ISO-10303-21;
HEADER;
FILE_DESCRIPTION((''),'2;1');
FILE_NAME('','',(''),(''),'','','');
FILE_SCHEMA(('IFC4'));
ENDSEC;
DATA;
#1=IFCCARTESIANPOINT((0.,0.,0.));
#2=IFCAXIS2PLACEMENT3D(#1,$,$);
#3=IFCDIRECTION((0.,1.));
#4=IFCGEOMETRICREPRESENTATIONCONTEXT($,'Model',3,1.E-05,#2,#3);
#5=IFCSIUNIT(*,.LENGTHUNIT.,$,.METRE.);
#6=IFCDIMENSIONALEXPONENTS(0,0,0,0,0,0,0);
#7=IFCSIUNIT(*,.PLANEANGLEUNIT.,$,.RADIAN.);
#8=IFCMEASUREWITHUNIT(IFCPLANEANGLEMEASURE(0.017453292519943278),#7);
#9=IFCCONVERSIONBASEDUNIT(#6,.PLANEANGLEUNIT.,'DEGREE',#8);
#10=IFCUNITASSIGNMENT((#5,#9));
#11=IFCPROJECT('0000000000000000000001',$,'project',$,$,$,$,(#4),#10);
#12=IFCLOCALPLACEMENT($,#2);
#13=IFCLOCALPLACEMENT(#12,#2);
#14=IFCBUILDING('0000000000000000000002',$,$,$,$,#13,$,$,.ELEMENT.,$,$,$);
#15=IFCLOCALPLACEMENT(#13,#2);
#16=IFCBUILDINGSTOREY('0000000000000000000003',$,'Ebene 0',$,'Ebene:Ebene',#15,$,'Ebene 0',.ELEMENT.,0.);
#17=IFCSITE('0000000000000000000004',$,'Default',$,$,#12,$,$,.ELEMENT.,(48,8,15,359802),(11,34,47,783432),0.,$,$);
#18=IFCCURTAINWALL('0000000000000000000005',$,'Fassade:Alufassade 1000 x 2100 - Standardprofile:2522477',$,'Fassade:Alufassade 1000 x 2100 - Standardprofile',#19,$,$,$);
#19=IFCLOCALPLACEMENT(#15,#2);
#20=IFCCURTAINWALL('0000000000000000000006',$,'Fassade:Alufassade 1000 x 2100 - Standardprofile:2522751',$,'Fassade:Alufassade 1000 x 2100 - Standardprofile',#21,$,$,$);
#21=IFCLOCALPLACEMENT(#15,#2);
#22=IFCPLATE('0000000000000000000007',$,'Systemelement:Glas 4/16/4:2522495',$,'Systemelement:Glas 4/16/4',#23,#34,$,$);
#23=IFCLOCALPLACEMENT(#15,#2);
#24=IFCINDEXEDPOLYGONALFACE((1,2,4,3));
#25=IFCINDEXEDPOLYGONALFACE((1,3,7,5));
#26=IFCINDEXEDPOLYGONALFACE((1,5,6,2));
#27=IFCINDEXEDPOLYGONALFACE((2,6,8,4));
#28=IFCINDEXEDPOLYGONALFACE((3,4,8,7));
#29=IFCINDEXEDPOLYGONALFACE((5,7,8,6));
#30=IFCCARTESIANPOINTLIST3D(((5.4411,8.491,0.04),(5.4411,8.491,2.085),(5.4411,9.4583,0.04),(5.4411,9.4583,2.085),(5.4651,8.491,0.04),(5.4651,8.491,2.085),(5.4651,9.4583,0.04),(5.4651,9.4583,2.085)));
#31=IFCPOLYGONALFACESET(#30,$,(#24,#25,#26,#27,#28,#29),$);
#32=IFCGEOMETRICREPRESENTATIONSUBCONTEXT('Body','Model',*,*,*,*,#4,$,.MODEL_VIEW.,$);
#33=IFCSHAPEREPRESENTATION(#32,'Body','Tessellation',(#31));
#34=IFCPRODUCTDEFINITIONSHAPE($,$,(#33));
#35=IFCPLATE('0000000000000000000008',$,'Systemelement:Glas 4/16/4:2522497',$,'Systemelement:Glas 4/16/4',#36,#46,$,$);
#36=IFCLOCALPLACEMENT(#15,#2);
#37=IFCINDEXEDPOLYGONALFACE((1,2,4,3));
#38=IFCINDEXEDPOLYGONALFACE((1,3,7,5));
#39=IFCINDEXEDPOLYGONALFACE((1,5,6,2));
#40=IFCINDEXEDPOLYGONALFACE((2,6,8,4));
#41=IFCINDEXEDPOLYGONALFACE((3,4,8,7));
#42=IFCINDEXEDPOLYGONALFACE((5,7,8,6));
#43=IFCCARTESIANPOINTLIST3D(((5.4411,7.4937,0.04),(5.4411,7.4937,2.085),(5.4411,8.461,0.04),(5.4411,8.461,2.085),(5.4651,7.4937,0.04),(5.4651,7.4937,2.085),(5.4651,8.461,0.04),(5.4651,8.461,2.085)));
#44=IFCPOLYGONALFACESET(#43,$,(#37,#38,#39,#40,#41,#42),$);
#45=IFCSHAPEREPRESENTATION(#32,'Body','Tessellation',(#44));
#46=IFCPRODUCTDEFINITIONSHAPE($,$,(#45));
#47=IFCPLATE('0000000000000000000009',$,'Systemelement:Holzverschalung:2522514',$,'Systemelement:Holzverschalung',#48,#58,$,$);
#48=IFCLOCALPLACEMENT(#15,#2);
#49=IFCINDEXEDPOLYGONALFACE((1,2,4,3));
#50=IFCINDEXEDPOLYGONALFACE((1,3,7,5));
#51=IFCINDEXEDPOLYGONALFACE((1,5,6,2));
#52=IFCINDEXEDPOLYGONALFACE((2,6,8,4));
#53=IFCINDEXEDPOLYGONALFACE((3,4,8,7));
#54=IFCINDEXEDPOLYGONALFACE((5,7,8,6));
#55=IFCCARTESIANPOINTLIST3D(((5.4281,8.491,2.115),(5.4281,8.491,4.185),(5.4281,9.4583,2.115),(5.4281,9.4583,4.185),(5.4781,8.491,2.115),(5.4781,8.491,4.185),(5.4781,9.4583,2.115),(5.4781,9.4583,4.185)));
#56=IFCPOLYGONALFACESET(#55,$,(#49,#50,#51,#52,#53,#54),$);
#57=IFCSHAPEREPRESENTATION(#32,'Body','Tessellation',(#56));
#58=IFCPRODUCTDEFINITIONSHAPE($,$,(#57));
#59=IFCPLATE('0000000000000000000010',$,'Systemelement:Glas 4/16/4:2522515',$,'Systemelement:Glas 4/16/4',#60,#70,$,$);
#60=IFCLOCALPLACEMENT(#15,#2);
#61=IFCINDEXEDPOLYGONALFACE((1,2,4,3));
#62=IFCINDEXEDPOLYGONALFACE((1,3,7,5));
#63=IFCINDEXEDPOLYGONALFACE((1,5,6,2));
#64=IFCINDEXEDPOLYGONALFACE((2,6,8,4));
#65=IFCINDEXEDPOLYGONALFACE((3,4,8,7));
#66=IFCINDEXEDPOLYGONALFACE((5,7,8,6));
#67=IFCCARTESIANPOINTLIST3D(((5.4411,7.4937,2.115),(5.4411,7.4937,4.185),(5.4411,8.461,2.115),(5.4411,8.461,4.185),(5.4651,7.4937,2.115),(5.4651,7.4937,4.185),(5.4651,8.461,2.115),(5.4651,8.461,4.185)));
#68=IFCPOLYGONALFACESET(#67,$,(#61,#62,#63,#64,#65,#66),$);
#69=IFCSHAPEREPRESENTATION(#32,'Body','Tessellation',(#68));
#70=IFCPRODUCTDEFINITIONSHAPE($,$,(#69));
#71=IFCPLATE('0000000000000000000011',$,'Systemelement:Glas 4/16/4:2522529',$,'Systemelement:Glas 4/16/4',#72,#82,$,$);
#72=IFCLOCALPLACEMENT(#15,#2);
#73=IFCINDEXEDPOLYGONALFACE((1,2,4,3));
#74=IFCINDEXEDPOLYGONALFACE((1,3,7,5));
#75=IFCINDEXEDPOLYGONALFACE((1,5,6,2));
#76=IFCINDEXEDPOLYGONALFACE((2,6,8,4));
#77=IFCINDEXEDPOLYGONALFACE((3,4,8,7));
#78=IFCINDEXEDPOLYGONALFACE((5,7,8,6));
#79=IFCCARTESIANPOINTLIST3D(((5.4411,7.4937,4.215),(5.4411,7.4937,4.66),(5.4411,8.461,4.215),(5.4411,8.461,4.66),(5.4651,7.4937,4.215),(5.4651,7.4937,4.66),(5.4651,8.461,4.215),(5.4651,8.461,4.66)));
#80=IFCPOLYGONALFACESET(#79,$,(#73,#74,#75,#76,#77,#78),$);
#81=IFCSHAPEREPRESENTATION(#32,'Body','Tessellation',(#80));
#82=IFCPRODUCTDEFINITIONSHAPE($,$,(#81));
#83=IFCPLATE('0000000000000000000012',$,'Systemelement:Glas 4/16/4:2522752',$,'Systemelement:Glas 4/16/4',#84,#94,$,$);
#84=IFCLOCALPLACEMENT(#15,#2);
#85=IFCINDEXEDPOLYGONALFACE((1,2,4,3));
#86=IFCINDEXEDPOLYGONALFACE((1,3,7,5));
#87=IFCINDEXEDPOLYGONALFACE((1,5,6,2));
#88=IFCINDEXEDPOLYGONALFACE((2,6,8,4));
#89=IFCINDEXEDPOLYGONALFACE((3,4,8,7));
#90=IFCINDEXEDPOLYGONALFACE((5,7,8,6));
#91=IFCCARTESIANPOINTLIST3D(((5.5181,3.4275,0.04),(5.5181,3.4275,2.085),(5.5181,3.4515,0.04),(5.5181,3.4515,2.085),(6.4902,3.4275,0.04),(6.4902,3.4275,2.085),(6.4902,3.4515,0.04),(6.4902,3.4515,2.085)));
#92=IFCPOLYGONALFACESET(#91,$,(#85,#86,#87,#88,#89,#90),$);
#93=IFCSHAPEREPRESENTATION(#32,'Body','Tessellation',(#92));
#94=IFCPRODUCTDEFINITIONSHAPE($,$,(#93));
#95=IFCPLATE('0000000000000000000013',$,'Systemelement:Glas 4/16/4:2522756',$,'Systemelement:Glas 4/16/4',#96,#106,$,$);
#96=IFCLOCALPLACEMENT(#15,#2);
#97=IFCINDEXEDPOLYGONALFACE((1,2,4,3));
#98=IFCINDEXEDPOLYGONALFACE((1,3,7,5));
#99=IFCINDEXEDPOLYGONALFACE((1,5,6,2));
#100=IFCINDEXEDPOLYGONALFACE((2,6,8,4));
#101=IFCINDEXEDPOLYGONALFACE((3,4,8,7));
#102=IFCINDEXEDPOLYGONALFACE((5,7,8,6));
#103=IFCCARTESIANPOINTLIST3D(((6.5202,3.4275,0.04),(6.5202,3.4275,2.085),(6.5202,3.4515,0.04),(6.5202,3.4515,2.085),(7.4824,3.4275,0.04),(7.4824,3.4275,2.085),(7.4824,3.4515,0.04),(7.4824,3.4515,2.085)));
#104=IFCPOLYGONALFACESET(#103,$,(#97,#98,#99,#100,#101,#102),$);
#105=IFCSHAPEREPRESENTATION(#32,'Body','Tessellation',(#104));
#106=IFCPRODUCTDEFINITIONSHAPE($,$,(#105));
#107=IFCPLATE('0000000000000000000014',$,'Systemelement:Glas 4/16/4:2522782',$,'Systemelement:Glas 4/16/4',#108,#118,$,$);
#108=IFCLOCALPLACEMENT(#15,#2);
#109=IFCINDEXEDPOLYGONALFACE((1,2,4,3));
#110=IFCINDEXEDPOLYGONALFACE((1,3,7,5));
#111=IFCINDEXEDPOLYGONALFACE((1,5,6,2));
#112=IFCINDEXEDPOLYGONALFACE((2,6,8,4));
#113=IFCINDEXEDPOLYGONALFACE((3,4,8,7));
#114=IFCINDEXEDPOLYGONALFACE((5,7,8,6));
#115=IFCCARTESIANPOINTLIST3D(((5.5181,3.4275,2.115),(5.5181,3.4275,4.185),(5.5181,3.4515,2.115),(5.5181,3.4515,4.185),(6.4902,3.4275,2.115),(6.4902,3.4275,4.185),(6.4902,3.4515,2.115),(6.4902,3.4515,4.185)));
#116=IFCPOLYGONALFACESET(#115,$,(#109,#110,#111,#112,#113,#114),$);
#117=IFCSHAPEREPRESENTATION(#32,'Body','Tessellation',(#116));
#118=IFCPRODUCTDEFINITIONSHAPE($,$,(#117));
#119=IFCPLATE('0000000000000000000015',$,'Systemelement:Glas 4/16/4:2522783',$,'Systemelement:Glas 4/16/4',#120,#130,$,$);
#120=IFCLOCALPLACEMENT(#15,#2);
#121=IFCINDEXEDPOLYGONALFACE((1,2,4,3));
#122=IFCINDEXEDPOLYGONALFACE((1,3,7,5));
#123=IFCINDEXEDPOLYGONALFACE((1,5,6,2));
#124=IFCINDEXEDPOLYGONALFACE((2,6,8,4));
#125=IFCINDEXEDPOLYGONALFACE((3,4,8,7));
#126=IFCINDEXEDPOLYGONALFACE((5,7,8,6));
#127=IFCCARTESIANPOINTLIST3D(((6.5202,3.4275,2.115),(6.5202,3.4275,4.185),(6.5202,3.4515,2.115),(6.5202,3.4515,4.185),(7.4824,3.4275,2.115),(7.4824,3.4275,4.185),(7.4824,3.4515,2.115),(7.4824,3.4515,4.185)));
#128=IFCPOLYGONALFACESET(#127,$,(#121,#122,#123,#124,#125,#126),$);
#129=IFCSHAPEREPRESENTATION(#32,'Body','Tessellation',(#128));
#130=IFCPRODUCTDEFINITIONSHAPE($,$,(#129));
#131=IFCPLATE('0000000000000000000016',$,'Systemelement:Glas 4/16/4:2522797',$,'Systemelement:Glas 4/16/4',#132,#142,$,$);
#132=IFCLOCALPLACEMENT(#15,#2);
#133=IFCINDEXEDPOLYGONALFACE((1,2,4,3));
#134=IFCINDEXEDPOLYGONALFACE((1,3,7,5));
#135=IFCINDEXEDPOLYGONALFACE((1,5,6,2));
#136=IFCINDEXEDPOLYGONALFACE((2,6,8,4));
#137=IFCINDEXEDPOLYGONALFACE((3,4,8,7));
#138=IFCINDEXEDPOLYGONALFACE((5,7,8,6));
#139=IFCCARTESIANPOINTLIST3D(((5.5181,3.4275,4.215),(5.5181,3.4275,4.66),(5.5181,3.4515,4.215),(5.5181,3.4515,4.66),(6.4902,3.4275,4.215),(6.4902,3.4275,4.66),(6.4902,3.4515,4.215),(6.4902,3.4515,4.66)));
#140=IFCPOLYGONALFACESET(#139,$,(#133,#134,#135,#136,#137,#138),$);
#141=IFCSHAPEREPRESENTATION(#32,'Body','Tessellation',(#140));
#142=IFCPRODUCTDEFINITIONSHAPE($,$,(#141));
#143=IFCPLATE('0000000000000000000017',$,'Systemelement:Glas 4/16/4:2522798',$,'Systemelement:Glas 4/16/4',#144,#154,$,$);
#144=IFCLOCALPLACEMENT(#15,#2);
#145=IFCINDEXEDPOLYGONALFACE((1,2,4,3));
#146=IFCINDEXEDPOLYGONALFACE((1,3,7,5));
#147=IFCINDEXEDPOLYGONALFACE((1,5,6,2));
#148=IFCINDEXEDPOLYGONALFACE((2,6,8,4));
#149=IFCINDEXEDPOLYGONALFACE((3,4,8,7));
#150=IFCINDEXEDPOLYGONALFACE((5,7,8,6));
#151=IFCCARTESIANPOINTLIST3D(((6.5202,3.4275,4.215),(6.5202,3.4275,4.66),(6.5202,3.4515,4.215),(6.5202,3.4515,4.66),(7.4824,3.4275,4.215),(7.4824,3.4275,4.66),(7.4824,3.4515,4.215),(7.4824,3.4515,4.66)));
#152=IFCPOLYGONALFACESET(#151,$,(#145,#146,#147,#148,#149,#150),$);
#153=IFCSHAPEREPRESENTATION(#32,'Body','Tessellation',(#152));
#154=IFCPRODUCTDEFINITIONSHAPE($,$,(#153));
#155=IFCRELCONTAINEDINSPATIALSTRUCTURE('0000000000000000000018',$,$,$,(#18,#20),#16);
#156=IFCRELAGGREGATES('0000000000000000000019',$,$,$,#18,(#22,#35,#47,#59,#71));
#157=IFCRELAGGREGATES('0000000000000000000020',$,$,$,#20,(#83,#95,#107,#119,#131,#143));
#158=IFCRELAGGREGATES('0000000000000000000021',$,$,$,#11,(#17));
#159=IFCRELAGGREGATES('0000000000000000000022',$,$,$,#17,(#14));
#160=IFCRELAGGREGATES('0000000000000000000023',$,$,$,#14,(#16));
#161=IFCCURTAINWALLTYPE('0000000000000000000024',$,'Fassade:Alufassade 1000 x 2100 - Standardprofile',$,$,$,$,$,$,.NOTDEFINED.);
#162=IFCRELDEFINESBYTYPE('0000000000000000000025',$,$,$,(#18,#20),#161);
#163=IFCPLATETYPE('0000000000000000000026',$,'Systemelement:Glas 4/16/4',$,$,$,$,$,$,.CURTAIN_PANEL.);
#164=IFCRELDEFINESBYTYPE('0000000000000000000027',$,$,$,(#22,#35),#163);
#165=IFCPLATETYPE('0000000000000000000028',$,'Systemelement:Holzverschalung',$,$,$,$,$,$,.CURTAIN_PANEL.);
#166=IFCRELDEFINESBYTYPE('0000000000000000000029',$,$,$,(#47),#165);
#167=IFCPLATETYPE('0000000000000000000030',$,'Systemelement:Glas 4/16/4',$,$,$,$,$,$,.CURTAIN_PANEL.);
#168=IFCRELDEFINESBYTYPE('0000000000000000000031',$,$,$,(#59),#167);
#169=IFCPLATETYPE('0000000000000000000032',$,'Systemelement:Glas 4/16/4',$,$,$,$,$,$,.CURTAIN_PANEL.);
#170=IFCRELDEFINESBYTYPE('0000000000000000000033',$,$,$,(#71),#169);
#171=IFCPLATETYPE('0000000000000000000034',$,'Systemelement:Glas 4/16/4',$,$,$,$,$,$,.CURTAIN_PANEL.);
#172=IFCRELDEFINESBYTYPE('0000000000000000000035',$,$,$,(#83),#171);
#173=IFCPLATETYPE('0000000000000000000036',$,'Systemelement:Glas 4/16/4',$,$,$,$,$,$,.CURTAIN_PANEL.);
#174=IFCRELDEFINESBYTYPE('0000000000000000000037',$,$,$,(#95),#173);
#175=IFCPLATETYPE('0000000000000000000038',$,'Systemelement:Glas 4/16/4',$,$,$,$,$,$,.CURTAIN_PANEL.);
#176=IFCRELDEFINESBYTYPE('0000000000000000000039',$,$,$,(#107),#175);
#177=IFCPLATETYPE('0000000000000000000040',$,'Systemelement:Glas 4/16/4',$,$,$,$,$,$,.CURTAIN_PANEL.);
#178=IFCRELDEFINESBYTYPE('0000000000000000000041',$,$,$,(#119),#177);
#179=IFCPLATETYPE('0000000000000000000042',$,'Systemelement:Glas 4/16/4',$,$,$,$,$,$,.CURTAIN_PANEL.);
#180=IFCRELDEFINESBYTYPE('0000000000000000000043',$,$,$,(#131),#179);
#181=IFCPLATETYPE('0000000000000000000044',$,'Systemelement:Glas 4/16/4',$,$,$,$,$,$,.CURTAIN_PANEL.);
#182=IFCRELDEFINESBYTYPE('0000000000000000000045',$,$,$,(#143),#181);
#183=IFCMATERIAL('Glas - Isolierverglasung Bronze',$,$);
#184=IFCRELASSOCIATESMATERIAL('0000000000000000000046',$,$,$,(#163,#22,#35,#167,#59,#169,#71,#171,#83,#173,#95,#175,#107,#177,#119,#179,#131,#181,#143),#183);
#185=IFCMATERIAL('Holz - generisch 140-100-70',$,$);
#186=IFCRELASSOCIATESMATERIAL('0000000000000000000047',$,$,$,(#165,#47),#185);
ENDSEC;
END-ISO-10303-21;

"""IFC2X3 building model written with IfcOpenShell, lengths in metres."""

from ifc_helpers import new_model, entity, si_unit, converted_unit, direction, frame, origin, origin_2d_with_axis, place, context, subcontext, project, spatial, rectangle, extrude, source, transform, mapped, material, type_object, type_shapes, element, aggregate, save


model = new_model("IFC2X3")

# Units and contexts
model_context = context("Model", 3, precision=1e-05, world=origin(), true_north=direction((0.0, 1.0)))
body_context = subcontext(model_context, "Body", "Model", "MODEL_VIEW")
ifc_project = project(units=[si_unit("LENGTHUNIT", "METRE"), converted_unit("PLANEANGLEUNIT", "DEGREE", entity("IfcPlaneAngleMeasure", 0.017453292519943278), si_unit("PLANEANGLEUNIT", "RADIAN"), dimensions=[0, 0, 0, 0, 0, 0, 0])], contexts=[model_context])

# Site, building, storey
site_placement = place(None, origin())
site = spatial("IfcSite", under=ifc_project, at=site_placement, Name="Default", CompositionType="ELEMENT", RefLatitude=(48, 8, 15, 359802), RefLongitude=(11, 34, 47, 783432), RefElevation=0.0)
building_placement = place(site_placement, origin())
building = spatial("IfcBuilding", under=site, at=building_placement, CompositionType="ELEMENT")
storey_placement = place(building_placement, origin())
storey = spatial("IfcBuildingStorey", under=building, at=storey_placement, Name="Ebene 0", ObjectType="Ebene:Ebene", LongName="Ebene 0", CompositionType="ELEMENT", Elevation=0.0)

# Curtain walls
curtain_wall_type = type_object("IfcCurtainWallType", Name="Fassade:Alufassade 1000 x 2100 - Standardprofile", PredefinedType="NOTDEFINED")
curtain_wall_1_placement = place(storey_placement, origin())
curtain_wall_1 = element("IfcCurtainWall", 1, at=curtain_wall_1_placement, inside=storey, type_object=curtain_wall_type, Name="Fassade:Alufassade 1000 x 2100 - Standardprofile:2522477", ObjectType="Fassade:Alufassade 1000 x 2100 - Standardprofile")
curtain_wall_2_placement = place(storey_placement, origin())
curtain_wall_2 = element("IfcCurtainWall", 2, at=curtain_wall_2_placement, inside=storey, type_object=curtain_wall_type, Name="Fassade:Alufassade 1000 x 2100 - Standardprofile:2522751", ObjectType="Fassade:Alufassade 1000 x 2100 - Standardprofile")

# Plates
ifc_material_1 = material(Name="Glas - Isolierverglasung Bronze")
plate_type_1 = type_object("IfcPlateType", Name="Systemelement:Glas 4/16/4", PredefinedType="CURTAIN_PANEL", material=ifc_material_1)
shared_shape_1 = source(origin(), body_context, "Body", "SweptSolid", [
    extrude(rectangle(XDim=0.024, YDim=0.9673, at=origin_2d_with_axis()), frame((0.0, 0.0, 0.0), z_axis=(0.0, 0.0, 1.0), x_axis=(0.0, 1.0, 0.0)), (0.0, 0.0, 1.0), 2.045),
])
type_shapes(plate_type_1, [shared_shape_1])
plate_1_placement = place(curtain_wall_1_placement, frame((5.4531, 8.9747, 0.04), z_axis=(0.0, 0.0, 1.0), x_axis=(0.0, -1.0, 0.0)))
plate_1 = element("IfcPlate", 3, at=plate_1_placement, type_object=plate_type_1, material=ifc_material_1, Name="Systemelement:Glas 4/16/4:2522495", ObjectType="Systemelement:Glas 4/16/4", context=body_context, shape_type="MappedRepresentation", body=[
    mapped(shared_shape_1, transform((0.0, 0.0, 0.0), scale=1.0)),
])
plate_2_placement = place(curtain_wall_1_placement, frame((5.4531, 7.9774, 0.04), z_axis=(0.0, 0.0, 1.0), x_axis=(0.0, -1.0, 0.0)))
plate_2 = element("IfcPlate", 4, at=plate_2_placement, type_object=plate_type_1, material=ifc_material_1, Name="Systemelement:Glas 4/16/4:2522497", ObjectType="Systemelement:Glas 4/16/4", context=body_context, shape_type="MappedRepresentation", body=[
    mapped(shared_shape_1, transform((0.0, 0.0, 0.0), scale=1.0)),
])
ifc_material_2 = material(Name="Holz - generisch 140-100-70")
plate_type_2 = type_object("IfcPlateType", Name="Systemelement:Holzverschalung", PredefinedType="CURTAIN_PANEL", material=ifc_material_2)
shared_shape_2 = source(origin(), body_context, "Body", "SweptSolid", [
    extrude(rectangle(XDim=0.05, YDim=0.9673, at=origin_2d_with_axis()), frame((0.0, 0.0, 0.0), z_axis=(0.0, 0.0, 1.0), x_axis=(0.0, 1.0, 0.0)), (0.0, 0.0, 1.0), 2.07),
])
type_shapes(plate_type_2, [shared_shape_2])
plate_3_placement = place(curtain_wall_1_placement, frame((5.4531, 8.9747, 2.115), z_axis=(0.0, 0.0, 1.0), x_axis=(0.0, -1.0, 0.0)))
plate_3 = element("IfcPlate", 5, at=plate_3_placement, type_object=plate_type_2, material=ifc_material_2, Name="Systemelement:Holzverschalung:2522514", ObjectType="Systemelement:Holzverschalung", context=body_context, shape_type="MappedRepresentation", body=[
    mapped(shared_shape_2, transform((0.0, 0.0, 0.0), scale=1.0)),
])
plate_type_3 = type_object("IfcPlateType", Name="Systemelement:Glas 4/16/4", PredefinedType="CURTAIN_PANEL", material=ifc_material_1)
shared_shape_3 = source(origin(), body_context, "Body", "SweptSolid", [
    extrude(rectangle(XDim=0.024, YDim=0.9673, at=origin_2d_with_axis()), frame((0.0, 0.0, 0.0), z_axis=(0.0, 0.0, 1.0), x_axis=(0.0, 1.0, 0.0)), (0.0, 0.0, 1.0), 2.07),
])
type_shapes(plate_type_3, [shared_shape_3])
plate_4_placement = place(curtain_wall_1_placement, frame((5.4531, 7.9774, 2.115), z_axis=(0.0, 0.0, 1.0), x_axis=(0.0, -1.0, 0.0)))
plate_4 = element("IfcPlate", 6, at=plate_4_placement, type_object=plate_type_3, material=ifc_material_1, Name="Systemelement:Glas 4/16/4:2522515", ObjectType="Systemelement:Glas 4/16/4", context=body_context, shape_type="MappedRepresentation", body=[
    mapped(shared_shape_3, transform((0.0, 0.0, 0.0), scale=1.0)),
])
plate_type_4 = type_object("IfcPlateType", Name="Systemelement:Glas 4/16/4", PredefinedType="CURTAIN_PANEL", material=ifc_material_1)
shared_shape_4 = source(origin(), body_context, "Body", "SweptSolid", [
    extrude(rectangle(XDim=0.024, YDim=0.9673, at=origin_2d_with_axis()), frame((0.0, 0.0, 0.0), z_axis=(0.0, 0.0, 1.0), x_axis=(0.0, 1.0, 0.0)), (0.0, 0.0, 1.0), 0.445),
])
type_shapes(plate_type_4, [shared_shape_4])
plate_5_placement = place(curtain_wall_1_placement, frame((5.4531, 7.9774, 4.215), z_axis=(0.0, 0.0, 1.0), x_axis=(0.0, -1.0, 0.0)))
plate_5 = element("IfcPlate", 7, at=plate_5_placement, type_object=plate_type_4, material=ifc_material_1, Name="Systemelement:Glas 4/16/4:2522529", ObjectType="Systemelement:Glas 4/16/4", context=body_context, shape_type="MappedRepresentation", body=[
    mapped(shared_shape_4, transform((0.0, 0.0, 0.0), scale=1.0)),
])
aggregate(curtain_wall_1, [plate_1, plate_2, plate_3, plate_4, plate_5])
plate_type_5 = type_object("IfcPlateType", Name="Systemelement:Glas 4/16/4", PredefinedType="CURTAIN_PANEL", material=ifc_material_1)
shared_shape_5 = source(origin(), body_context, "Body", "SweptSolid", [
    extrude(rectangle(XDim=0.024, YDim=0.9721, at=origin_2d_with_axis()), frame((0.0, 0.0, 0.0), z_axis=(0.0, 0.0, 1.0), x_axis=(0.0, 1.0, 0.0)), (0.0, 0.0, 1.0), 2.045),
])
type_shapes(plate_type_5, [shared_shape_5])
plate_6_placement = place(curtain_wall_2_placement, frame((6.0042, 3.4395, 0.04)))
plate_6 = element("IfcPlate", 8, at=plate_6_placement, type_object=plate_type_5, material=ifc_material_1, Name="Systemelement:Glas 4/16/4:2522752", ObjectType="Systemelement:Glas 4/16/4", context=body_context, shape_type="MappedRepresentation", body=[
    mapped(shared_shape_5, transform((0.0, 0.0, 0.0), scale=1.0)),
])
plate_type_6 = type_object("IfcPlateType", Name="Systemelement:Glas 4/16/4", PredefinedType="CURTAIN_PANEL", material=ifc_material_1)
shared_shape_6 = source(origin(), body_context, "Body", "SweptSolid", [
    extrude(rectangle(XDim=0.024, YDim=0.9621, at=origin_2d_with_axis()), frame((0.0, 0.0, 0.0), z_axis=(0.0, 0.0, 1.0), x_axis=(0.0, 1.0, 0.0)), (0.0, 0.0, 1.0), 2.045),
])
type_shapes(plate_type_6, [shared_shape_6])
plate_7_placement = place(curtain_wall_2_placement, frame((7.0013, 3.4395, 0.04)))
plate_7 = element("IfcPlate", 9, at=plate_7_placement, type_object=plate_type_6, material=ifc_material_1, Name="Systemelement:Glas 4/16/4:2522756", ObjectType="Systemelement:Glas 4/16/4", context=body_context, shape_type="MappedRepresentation", body=[
    mapped(shared_shape_6, transform((0.0, 0.0, 0.0), scale=1.0)),
])
plate_type_7 = type_object("IfcPlateType", Name="Systemelement:Glas 4/16/4", PredefinedType="CURTAIN_PANEL", material=ifc_material_1)
shared_shape_7 = source(origin(), body_context, "Body", "SweptSolid", [
    extrude(rectangle(XDim=0.024, YDim=0.9721, at=origin_2d_with_axis()), frame((0.0, 0.0, 0.0), z_axis=(0.0, 0.0, 1.0), x_axis=(0.0, 1.0, 0.0)), (0.0, 0.0, 1.0), 2.07),
])
type_shapes(plate_type_7, [shared_shape_7])
plate_8_placement = place(curtain_wall_2_placement, frame((6.0042, 3.4395, 2.115)))
plate_8 = element("IfcPlate", 10, at=plate_8_placement, type_object=plate_type_7, material=ifc_material_1, Name="Systemelement:Glas 4/16/4:2522782", ObjectType="Systemelement:Glas 4/16/4", context=body_context, shape_type="MappedRepresentation", body=[
    mapped(shared_shape_7, transform((0.0, 0.0, 0.0), scale=1.0)),
])
plate_type_8 = type_object("IfcPlateType", Name="Systemelement:Glas 4/16/4", PredefinedType="CURTAIN_PANEL", material=ifc_material_1)
shared_shape_8 = source(origin(), body_context, "Body", "SweptSolid", [
    extrude(rectangle(XDim=0.024, YDim=0.9621, at=origin_2d_with_axis()), frame((0.0, 0.0, 0.0), z_axis=(0.0, 0.0, 1.0), x_axis=(0.0, 1.0, 0.0)), (0.0, 0.0, 1.0), 2.07),
])
type_shapes(plate_type_8, [shared_shape_8])
plate_9_placement = place(curtain_wall_2_placement, frame((7.0013, 3.4395, 2.115)))
plate_9 = element("IfcPlate", 11, at=plate_9_placement, type_object=plate_type_8, material=ifc_material_1, Name="Systemelement:Glas 4/16/4:2522783", ObjectType="Systemelement:Glas 4/16/4", context=body_context, shape_type="MappedRepresentation", body=[
    mapped(shared_shape_8, transform((0.0, 0.0, 0.0), scale=1.0)),
])
plate_type_9 = type_object("IfcPlateType", Name="Systemelement:Glas 4/16/4", PredefinedType="CURTAIN_PANEL", material=ifc_material_1)
shared_shape_9 = source(origin(), body_context, "Body", "SweptSolid", [
    extrude(rectangle(XDim=0.024, YDim=0.9721, at=origin_2d_with_axis()), frame((0.0, 0.0, 0.0), z_axis=(0.0, 0.0, 1.0), x_axis=(0.0, 1.0, 0.0)), (0.0, 0.0, 1.0), 0.445),
])
type_shapes(plate_type_9, [shared_shape_9])
plate_10_placement = place(curtain_wall_2_placement, frame((6.0042, 3.4395, 4.215)))
plate_10 = element("IfcPlate", 12, at=plate_10_placement, type_object=plate_type_9, material=ifc_material_1, Name="Systemelement:Glas 4/16/4:2522797", ObjectType="Systemelement:Glas 4/16/4", context=body_context, shape_type="MappedRepresentation", body=[
    mapped(shared_shape_9, transform((0.0, 0.0, 0.0), scale=1.0)),
])
plate_type_10 = type_object("IfcPlateType", Name="Systemelement:Glas 4/16/4", PredefinedType="CURTAIN_PANEL", material=ifc_material_1)
shared_shape_10 = source(origin(), body_context, "Body", "SweptSolid", [
    extrude(rectangle(XDim=0.024, YDim=0.9621, at=origin_2d_with_axis()), frame((0.0, 0.0, 0.0), z_axis=(0.0, 0.0, 1.0), x_axis=(0.0, 1.0, 0.0)), (0.0, 0.0, 1.0), 0.445),
])
type_shapes(plate_type_10, [shared_shape_10])
plate_11_placement = place(curtain_wall_2_placement, frame((7.0013, 3.4395, 4.215)))
plate_11 = element("IfcPlate", 13, at=plate_11_placement, type_object=plate_type_10, material=ifc_material_1, Name="Systemelement:Glas 4/16/4:2522798", ObjectType="Systemelement:Glas 4/16/4", context=body_context, shape_type="MappedRepresentation", body=[
    mapped(shared_shape_10, transform((0.0, 0.0, 0.0), scale=1.0)),
])
aggregate(curtain_wall_2, [plate_6, plate_7, plate_8, plate_9, plate_10, plate_11])

save(model, "model.ifc")
